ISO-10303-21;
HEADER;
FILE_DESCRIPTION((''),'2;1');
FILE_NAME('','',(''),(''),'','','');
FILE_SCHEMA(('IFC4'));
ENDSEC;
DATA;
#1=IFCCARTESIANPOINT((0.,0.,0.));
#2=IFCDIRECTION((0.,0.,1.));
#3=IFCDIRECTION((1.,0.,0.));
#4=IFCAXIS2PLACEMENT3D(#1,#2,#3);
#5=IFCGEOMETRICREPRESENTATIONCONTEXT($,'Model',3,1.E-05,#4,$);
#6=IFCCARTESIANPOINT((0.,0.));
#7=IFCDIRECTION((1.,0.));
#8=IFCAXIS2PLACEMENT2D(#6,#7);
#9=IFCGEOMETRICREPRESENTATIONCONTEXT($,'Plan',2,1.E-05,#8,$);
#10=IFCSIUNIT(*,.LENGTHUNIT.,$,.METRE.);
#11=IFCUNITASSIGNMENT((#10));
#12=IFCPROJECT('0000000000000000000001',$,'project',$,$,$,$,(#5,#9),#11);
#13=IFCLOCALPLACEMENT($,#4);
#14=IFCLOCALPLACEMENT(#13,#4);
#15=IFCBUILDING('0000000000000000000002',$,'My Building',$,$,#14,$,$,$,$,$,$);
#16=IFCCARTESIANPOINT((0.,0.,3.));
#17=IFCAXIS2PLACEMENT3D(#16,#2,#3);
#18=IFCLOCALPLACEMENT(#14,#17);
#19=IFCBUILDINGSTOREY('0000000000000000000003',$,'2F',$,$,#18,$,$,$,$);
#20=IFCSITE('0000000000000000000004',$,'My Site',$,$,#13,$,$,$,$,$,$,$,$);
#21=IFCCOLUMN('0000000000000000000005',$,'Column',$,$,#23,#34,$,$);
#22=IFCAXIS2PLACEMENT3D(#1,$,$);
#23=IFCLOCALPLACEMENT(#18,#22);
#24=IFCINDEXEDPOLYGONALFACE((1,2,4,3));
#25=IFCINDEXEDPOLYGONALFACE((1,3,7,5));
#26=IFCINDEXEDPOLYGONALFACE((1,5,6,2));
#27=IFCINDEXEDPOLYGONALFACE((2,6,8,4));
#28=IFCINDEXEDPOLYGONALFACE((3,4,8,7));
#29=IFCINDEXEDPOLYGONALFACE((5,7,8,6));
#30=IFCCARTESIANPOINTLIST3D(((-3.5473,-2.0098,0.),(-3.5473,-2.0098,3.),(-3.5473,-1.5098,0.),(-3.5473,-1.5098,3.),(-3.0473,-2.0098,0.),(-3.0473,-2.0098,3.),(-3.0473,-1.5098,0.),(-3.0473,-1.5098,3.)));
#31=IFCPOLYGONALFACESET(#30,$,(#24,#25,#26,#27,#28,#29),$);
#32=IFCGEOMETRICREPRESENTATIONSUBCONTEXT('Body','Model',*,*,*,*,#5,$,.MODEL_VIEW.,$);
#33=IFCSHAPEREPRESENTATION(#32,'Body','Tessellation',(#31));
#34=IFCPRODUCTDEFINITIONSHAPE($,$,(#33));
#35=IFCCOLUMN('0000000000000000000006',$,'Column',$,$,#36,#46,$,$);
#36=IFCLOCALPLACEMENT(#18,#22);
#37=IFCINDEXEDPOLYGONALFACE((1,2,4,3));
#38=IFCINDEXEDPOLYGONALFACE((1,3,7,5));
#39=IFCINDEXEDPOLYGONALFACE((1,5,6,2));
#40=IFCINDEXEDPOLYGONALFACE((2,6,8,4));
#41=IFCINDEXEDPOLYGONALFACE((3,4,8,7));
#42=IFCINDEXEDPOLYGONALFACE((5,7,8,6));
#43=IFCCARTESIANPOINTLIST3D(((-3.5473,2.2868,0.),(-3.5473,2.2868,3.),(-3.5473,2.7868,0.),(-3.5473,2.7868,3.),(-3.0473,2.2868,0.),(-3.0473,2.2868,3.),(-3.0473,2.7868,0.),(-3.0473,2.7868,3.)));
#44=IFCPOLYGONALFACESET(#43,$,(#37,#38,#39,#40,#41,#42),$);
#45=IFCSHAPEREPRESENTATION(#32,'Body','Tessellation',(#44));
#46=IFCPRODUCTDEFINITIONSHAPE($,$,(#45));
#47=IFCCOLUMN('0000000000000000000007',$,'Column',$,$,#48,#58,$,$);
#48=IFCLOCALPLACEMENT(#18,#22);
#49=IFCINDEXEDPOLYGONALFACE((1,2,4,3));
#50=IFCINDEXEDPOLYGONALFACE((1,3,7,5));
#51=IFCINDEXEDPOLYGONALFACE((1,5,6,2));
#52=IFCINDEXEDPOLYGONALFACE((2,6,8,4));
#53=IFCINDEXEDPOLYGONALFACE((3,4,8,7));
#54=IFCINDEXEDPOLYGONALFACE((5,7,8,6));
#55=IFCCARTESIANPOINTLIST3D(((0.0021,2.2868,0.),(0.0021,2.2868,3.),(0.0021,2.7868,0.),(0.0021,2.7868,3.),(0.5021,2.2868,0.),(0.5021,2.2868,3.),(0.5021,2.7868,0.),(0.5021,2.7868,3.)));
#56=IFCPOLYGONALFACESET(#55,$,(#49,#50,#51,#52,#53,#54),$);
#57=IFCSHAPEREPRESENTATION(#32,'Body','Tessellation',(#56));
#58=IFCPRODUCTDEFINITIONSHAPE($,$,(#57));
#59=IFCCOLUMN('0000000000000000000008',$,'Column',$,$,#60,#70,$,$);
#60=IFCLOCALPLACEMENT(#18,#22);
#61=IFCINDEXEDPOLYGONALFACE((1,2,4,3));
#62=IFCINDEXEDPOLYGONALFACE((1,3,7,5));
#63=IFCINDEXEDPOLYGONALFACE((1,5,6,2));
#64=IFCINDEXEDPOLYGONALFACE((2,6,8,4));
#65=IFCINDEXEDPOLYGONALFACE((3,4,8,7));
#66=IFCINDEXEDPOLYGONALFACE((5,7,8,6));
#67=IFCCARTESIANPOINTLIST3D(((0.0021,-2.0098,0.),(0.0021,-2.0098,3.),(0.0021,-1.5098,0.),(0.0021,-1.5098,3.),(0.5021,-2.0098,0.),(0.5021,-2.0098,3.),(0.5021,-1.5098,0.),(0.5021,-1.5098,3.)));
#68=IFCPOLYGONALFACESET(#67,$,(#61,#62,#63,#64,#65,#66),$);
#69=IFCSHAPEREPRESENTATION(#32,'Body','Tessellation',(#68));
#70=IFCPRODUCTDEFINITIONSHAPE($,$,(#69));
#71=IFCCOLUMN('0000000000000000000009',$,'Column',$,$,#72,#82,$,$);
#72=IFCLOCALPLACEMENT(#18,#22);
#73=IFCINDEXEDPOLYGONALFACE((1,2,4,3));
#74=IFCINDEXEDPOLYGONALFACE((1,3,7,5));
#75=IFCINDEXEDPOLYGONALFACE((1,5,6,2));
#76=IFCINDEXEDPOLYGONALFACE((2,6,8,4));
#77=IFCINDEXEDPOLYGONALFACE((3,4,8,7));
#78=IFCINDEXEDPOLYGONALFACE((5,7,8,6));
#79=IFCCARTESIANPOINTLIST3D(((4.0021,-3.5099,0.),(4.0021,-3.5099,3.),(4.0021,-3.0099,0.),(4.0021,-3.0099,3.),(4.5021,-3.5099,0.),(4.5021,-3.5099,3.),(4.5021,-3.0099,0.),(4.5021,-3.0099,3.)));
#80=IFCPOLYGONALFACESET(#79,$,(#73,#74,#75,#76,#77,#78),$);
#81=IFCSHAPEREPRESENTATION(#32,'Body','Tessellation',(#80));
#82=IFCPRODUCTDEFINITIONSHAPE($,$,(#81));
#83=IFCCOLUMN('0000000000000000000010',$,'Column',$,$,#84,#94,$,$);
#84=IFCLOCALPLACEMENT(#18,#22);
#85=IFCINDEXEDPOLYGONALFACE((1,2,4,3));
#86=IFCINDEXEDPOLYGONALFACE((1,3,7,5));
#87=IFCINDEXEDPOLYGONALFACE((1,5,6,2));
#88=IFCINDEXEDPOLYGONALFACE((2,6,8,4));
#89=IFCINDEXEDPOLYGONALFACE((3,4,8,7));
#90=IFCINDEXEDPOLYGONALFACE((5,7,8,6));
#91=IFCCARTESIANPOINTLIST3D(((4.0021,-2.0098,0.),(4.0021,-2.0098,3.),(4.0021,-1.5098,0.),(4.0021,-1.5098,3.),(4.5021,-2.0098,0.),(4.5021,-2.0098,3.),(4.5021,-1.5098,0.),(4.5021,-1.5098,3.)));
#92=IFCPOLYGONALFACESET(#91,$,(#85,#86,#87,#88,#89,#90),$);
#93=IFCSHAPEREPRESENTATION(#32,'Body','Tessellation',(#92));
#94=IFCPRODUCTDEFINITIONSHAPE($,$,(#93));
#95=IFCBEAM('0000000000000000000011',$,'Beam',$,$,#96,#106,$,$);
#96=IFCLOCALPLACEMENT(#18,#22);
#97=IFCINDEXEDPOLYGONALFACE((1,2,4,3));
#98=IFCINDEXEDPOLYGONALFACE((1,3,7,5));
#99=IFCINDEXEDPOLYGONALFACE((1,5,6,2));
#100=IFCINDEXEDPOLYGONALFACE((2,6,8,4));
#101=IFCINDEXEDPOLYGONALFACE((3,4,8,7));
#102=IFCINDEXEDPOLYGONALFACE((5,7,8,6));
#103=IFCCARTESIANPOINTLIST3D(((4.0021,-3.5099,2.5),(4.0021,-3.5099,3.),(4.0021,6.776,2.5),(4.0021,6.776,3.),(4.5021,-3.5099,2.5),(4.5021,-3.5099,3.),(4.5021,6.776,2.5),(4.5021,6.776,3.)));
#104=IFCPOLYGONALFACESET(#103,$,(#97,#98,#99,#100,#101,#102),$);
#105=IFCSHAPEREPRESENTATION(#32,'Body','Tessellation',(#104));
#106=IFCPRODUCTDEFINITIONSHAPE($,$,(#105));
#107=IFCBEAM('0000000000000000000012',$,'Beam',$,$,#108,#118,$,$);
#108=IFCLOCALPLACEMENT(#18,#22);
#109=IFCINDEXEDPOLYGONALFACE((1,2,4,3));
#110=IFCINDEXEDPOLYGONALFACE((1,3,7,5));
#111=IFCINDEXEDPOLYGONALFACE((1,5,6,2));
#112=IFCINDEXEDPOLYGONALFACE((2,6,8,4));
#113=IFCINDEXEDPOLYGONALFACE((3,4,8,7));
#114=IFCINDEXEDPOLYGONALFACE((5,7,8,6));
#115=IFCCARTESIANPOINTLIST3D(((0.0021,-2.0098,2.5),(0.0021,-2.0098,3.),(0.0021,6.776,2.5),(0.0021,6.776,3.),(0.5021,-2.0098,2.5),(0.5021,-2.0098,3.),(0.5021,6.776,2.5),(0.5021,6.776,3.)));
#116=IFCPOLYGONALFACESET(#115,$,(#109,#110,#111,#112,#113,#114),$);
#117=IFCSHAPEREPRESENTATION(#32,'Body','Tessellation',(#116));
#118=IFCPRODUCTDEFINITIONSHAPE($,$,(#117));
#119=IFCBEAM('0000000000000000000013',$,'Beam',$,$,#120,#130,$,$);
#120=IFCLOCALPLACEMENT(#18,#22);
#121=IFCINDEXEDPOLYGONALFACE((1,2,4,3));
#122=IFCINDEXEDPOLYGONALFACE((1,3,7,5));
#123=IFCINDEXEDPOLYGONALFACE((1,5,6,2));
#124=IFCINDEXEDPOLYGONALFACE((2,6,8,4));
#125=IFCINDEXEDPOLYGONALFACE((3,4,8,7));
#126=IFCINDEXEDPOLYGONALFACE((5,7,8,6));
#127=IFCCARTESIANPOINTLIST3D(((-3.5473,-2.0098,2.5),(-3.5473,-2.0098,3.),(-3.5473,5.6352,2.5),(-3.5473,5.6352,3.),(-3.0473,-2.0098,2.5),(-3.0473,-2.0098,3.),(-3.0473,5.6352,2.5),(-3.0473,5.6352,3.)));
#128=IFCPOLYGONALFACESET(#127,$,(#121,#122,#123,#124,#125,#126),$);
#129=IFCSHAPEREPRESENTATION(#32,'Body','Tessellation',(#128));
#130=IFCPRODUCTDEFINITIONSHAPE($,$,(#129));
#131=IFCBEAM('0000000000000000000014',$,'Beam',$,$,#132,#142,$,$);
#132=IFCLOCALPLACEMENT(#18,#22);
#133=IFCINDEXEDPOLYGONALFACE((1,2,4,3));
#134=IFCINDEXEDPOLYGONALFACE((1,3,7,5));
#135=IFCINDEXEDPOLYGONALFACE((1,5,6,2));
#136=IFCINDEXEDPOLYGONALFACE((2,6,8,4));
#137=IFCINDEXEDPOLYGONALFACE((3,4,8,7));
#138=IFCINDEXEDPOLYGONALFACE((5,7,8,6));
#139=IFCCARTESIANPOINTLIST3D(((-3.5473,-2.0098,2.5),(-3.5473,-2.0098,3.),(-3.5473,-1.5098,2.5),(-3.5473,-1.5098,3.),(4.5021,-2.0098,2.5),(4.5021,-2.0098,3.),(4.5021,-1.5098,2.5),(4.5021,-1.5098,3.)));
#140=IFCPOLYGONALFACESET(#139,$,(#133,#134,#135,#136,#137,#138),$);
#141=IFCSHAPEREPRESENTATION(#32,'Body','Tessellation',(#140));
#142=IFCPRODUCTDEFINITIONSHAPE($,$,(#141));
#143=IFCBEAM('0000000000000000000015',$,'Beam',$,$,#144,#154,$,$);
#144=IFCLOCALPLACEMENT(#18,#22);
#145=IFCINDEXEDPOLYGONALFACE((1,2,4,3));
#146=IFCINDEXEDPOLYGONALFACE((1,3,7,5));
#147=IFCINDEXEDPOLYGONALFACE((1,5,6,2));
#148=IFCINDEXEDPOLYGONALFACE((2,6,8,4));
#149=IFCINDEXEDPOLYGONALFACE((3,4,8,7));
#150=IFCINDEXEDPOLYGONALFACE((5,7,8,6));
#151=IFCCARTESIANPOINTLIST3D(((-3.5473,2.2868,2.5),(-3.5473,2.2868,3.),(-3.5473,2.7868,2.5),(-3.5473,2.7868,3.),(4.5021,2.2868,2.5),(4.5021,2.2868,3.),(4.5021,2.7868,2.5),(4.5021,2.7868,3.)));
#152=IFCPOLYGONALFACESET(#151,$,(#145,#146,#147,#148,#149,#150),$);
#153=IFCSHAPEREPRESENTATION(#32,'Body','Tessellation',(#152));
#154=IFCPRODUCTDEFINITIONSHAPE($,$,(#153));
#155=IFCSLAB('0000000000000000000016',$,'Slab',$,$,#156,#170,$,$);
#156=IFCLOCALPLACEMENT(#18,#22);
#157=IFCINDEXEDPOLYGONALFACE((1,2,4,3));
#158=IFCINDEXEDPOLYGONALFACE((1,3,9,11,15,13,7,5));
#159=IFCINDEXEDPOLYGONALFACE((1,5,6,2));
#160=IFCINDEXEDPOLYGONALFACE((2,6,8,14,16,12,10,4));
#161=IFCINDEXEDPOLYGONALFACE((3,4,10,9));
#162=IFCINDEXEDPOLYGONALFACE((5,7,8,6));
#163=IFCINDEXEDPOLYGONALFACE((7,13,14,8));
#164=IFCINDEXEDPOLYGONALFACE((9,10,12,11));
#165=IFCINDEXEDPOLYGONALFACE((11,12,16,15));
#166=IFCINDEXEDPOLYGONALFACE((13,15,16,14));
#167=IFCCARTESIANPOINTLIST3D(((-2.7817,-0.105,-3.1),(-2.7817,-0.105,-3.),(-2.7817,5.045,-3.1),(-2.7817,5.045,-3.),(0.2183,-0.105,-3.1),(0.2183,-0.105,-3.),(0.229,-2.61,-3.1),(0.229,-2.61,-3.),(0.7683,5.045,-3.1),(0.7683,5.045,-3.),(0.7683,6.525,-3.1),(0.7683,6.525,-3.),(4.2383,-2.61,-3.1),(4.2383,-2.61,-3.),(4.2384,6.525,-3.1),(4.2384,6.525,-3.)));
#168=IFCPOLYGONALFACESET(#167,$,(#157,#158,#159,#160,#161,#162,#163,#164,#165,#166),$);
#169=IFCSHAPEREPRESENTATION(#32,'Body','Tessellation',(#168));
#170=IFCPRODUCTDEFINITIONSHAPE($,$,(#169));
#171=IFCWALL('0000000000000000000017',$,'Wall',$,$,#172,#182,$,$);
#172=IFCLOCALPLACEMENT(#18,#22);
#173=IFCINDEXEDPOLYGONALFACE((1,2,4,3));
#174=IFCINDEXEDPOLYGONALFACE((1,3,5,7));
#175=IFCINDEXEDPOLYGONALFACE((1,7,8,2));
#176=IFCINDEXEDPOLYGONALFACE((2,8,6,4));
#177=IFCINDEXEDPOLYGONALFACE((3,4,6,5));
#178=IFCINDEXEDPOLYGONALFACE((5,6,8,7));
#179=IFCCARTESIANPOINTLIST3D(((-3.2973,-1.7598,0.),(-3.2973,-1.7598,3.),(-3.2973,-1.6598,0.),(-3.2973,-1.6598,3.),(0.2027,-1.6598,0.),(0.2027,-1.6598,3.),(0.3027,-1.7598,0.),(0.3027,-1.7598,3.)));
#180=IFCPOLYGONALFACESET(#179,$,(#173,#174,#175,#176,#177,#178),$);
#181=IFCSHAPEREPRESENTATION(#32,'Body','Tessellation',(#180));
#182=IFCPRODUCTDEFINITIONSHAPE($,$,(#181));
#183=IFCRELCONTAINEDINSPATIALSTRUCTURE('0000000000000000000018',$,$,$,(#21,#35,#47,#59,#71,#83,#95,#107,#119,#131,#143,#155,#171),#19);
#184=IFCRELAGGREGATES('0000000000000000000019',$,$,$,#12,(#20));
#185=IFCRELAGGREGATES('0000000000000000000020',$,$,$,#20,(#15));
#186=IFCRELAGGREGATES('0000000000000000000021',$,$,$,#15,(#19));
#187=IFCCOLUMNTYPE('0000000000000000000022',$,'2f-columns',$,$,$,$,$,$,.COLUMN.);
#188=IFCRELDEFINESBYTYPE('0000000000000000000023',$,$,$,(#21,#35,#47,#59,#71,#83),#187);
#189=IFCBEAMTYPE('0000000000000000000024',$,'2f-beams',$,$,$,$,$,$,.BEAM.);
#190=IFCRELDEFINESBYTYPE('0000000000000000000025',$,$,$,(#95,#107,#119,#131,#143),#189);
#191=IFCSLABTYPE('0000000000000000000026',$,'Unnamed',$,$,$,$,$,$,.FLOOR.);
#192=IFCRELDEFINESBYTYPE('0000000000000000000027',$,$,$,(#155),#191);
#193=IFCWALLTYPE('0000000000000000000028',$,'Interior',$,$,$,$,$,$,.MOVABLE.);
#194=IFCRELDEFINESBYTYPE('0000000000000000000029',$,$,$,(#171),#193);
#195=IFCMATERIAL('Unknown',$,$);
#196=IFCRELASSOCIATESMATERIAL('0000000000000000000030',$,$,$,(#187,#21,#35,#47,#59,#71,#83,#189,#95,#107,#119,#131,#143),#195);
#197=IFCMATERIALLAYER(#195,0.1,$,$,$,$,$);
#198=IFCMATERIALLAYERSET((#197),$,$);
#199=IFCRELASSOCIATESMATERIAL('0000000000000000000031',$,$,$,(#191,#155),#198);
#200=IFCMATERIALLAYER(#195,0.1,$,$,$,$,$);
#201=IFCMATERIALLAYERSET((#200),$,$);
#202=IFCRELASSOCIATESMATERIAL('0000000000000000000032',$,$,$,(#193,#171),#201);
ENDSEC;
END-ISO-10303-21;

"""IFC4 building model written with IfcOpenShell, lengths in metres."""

from ifc_helpers import new_model, si_unit, frame, origin_with_axes, origin_2d_with_axis, place, context, subcontext, project, spatial, line, indexed_curve, rectangle, outline, extrude, material, layer, layer_set, layer_usage, material_profile, profile_set, profile_usage, type_object, element, save


model = new_model("IFC4")

# Units and contexts
model_context = context("Model", 3, precision=1e-05, world=origin_with_axes())
plan_context = context("Plan", 2, precision=1e-05, world=origin_2d_with_axis())
body_context_1 = subcontext(model_context, "Body", "Model", "MODEL_VIEW")
ifc_project = project(units=[si_unit("LENGTHUNIT", "METRE")], contexts=[model_context, plan_context])

# Site, building, storey
site_placement = place(None, origin_with_axes())
site = spatial("IfcSite", under=ifc_project, at=site_placement, Name="My Site")
building_placement = place(site_placement, origin_with_axes())
building = spatial("IfcBuilding", under=site, at=building_placement, Name="My Building")
storey_placement = place(building_placement, frame((0.0, 0.0, 3.0), z_axis=(0.0, 0.0, 1.0), x_axis=(1.0, 0.0, 0.0)))
storey = spatial("IfcBuildingStorey", under=building, at=storey_placement, Name="2F")

# Columns
ifc_material = material(Name="Unknown")
ifc_material_profile_1 = material_profile(ifc_material, rectangle(XDim=0.5, YDim=0.5))
ifc_profile_set_1 = profile_set([ifc_material_profile_1])
ifc_profile_usage_1 = profile_usage(ifc_profile_set_1, cardinal=5)
column_type = type_object("IfcColumnType", Name="2f-columns", PredefinedType="COLUMN", material=ifc_profile_set_1)
column_1_placement = place(storey_placement, frame((-3.2973, -1.7598, 0.0), z_axis=(0.0, 0.0, 1.0), x_axis=(1.0, 0.0, 0.0)))
element("IfcColumn", 1, at=column_1_placement, inside=storey, type_object=column_type, material=ifc_profile_usage_1, Name="Column", context=body_context_1, shape_type="SweptSolid", body=[
    extrude(rectangle(XDim=0.5, YDim=0.5), origin_with_axes(), (0.0, 0.0, 1.0), 3.0),
])
ifc_profile_usage_2 = profile_usage(ifc_profile_set_1, cardinal=5)
column_2_placement = place(storey_placement, frame((-3.2973, 2.5368, 0.0), z_axis=(0.0, 0.0, 1.0), x_axis=(1.0, 0.0, 0.0)))
element("IfcColumn", 2, at=column_2_placement, inside=storey, type_object=column_type, material=ifc_profile_usage_2, Name="Column", context=body_context_1, shape_type="SweptSolid", body=[
    extrude(rectangle(XDim=0.5, YDim=0.5), origin_with_axes(), (0.0, 0.0, 1.0), 3.0),
])
ifc_profile_usage_3 = profile_usage(ifc_profile_set_1, cardinal=5)
column_3_placement = place(storey_placement, frame((0.2521, 2.5368, 0.0), z_axis=(0.0, 0.0, 1.0), x_axis=(1.0, 0.0, 0.0)))
element("IfcColumn", 3, at=column_3_placement, inside=storey, type_object=column_type, material=ifc_profile_usage_3, Name="Column", context=body_context_1, shape_type="SweptSolid", body=[
    extrude(rectangle(XDim=0.5, YDim=0.5), origin_with_axes(), (0.0, 0.0, 1.0), 3.0),
])
ifc_profile_usage_4 = profile_usage(ifc_profile_set_1, cardinal=5)
column_4_placement = place(storey_placement, frame((0.2521, -1.7598, 0.0), z_axis=(0.0, 0.0, 1.0), x_axis=(1.0, 0.0, 0.0)))
element("IfcColumn", 4, at=column_4_placement, inside=storey, type_object=column_type, material=ifc_profile_usage_4, Name="Column", context=body_context_1, shape_type="SweptSolid", body=[
    extrude(rectangle(XDim=0.5, YDim=0.5), origin_with_axes(), (0.0, 0.0, 1.0), 3.0),
])
ifc_profile_usage_5 = profile_usage(ifc_profile_set_1, cardinal=5)
column_5_placement = place(storey_placement, frame((4.2521, -3.2599, 0.0), z_axis=(0.0, 0.0, 1.0), x_axis=(1.0, 0.0, 0.0)))
element("IfcColumn", 5, at=column_5_placement, inside=storey, type_object=column_type, material=ifc_profile_usage_5, Name="Column", context=body_context_1, shape_type="SweptSolid", body=[
    extrude(rectangle(XDim=0.5, YDim=0.5), origin_with_axes(), (0.0, 0.0, 1.0), 3.0),
])
ifc_profile_usage_6 = profile_usage(ifc_profile_set_1, cardinal=5)
column_6_placement = place(storey_placement, frame((4.2521, -1.7598, 0.0), z_axis=(0.0, 0.0, 1.0), x_axis=(1.0, 0.0, 0.0)))
element("IfcColumn", 6, at=column_6_placement, inside=storey, type_object=column_type, material=ifc_profile_usage_6, Name="Column", context=body_context_1, shape_type="SweptSolid", body=[
    extrude(rectangle(XDim=0.5, YDim=0.5), origin_with_axes(), (0.0, 0.0, 1.0), 3.0),
])

# Beams
ifc_material_profile_2 = material_profile(ifc_material, rectangle(XDim=0.5, YDim=0.5))
ifc_profile_set_2 = profile_set([ifc_material_profile_2])
ifc_profile_usage_7 = profile_usage(ifc_profile_set_2, cardinal=7)
beam_type = type_object("IfcBeamType", Name="2f-beams", PredefinedType="BEAM", material=ifc_profile_set_2)
beam_1_placement = place(storey_placement, frame((4.0021, -3.5099, 3.0), z_axis=(0.0, 1.0, 0.0), x_axis=(-1.0, 0.0, 0.0)))
element("IfcBeam", 7, at=beam_1_placement, inside=storey, type_object=beam_type, material=ifc_profile_usage_7, Name="Beam", context=body_context_1, shape_type="SweptSolid", body=[
    extrude(rectangle(XDim=0.5, YDim=0.5), frame((-0.25, -0.25, 0.0), z_axis=(0.0, 0.0, 1.0), x_axis=(1.0, 0.0, 0.0)), (0.0, 0.0, 1.0), 10.2859),
])
ifc_profile_usage_8 = profile_usage(ifc_profile_set_2, cardinal=7)
beam_2_placement = place(storey_placement, frame((0.0021, -2.0098, 3.0), z_axis=(0.0, 1.0, 0.0), x_axis=(-1.0, 0.0, 0.0)))
element("IfcBeam", 8, at=beam_2_placement, inside=storey, type_object=beam_type, material=ifc_profile_usage_8, Name="Beam", context=body_context_1, shape_type="SweptSolid", body=[
    extrude(rectangle(XDim=0.5, YDim=0.5), frame((-0.25, -0.25, 0.0), z_axis=(0.0, 0.0, 1.0), x_axis=(1.0, 0.0, 0.0)), (0.0, 0.0, 1.0), 8.7858),
])
ifc_profile_usage_9 = profile_usage(ifc_profile_set_2, cardinal=7)
beam_3_placement = place(storey_placement, frame((-3.5473, -2.0098, 3.0), z_axis=(0.0, 1.0, 0.0), x_axis=(-1.0, 0.0, 0.0)))
element("IfcBeam", 9, at=beam_3_placement, inside=storey, type_object=beam_type, material=ifc_profile_usage_9, Name="Beam", context=body_context_1, shape_type="SweptSolid", body=[
    extrude(rectangle(XDim=0.5, YDim=0.5), frame((-0.25, -0.25, 0.0), z_axis=(0.0, 0.0, 1.0), x_axis=(1.0, 0.0, 0.0)), (0.0, 0.0, 1.0), 7.645),
])
ifc_profile_usage_10 = profile_usage(ifc_profile_set_2, cardinal=7)
beam_4_placement = place(storey_placement, frame((4.5021, -2.0098, 3.0), z_axis=(-1.0, 0.0, 0.0), x_axis=(0.0, -1.0, 0.0)))
element("IfcBeam", 10, at=beam_4_placement, inside=storey, type_object=beam_type, material=ifc_profile_usage_10, Name="Beam", context=body_context_1, shape_type="SweptSolid", body=[
    extrude(rectangle(XDim=0.5, YDim=0.5), frame((-0.25, -0.25, 0.0), z_axis=(0.0, 0.0, 1.0), x_axis=(1.0, 0.0, 0.0)), (0.0, 0.0, 1.0), 8.0493),
])
ifc_profile_usage_11 = profile_usage(ifc_profile_set_2, cardinal=7)
beam_5_placement = place(storey_placement, frame((4.5021, 2.2868, 3.0), z_axis=(-1.0, 0.0, 0.0), x_axis=(0.0, -1.0, 0.0)))
element("IfcBeam", 11, at=beam_5_placement, inside=storey, type_object=beam_type, material=ifc_profile_usage_11, Name="Beam", context=body_context_1, shape_type="SweptSolid", body=[
    extrude(rectangle(XDim=0.5, YDim=0.5), frame((-0.25, -0.25, 0.0), z_axis=(0.0, 0.0, 1.0), x_axis=(1.0, 0.0, 0.0)), (0.0, 0.0, 1.0), 8.0493),
])

# Slab
ifc_layer_1 = layer(ifc_material, 0.1)
ifc_layer_set_1 = layer_set([ifc_layer_1])
ifc_layer_usage_1 = layer_usage(ifc_layer_set_1, "AXIS3", "POSITIVE", -0.1)
slab_type = type_object("IfcSlabType", Name="Unnamed", PredefinedType="FLOOR", material=ifc_layer_set_1)
slab_placement = place(storey_placement, frame((4.2383, -2.61, -3.0), z_axis=(0.0, 0.0, 1.0), x_axis=(1.0, 0.0, 0.0)))
element("IfcSlab", 12, at=slab_placement, inside=storey, type_object=slab_type, material=ifc_layer_usage_1, Name="Slab", context=body_context_1, shape_type="SweptSolid", body=[
    extrude(outline(indexed_curve([(0.0, 0.0), (0.0, 9.135), (-3.47, 9.135), (-3.47, 7.655), (-7.02, 7.655), (-7.02, 2.505), (-4.02, 2.505), (-4.0094, 0.0), (0.0, 0.0)])), frame((0.0, 0.0, -0.1), z_axis=(0.0, 0.0, 1.0), x_axis=(1.0, 0.0, 0.0)), (0.0, 0.0, 1.0), 0.1),
])

# Wall
ifc_layer_2 = layer(ifc_material, 0.1)
ifc_layer_set_2 = layer_set([ifc_layer_2])
ifc_layer_usage_2 = layer_usage(ifc_layer_set_2, "AXIS2", "POSITIVE", 0.0)
wall_type = type_object("IfcWallType", Name="Interior", PredefinedType="MOVABLE", material=ifc_layer_set_2)
wall_1_placement = place(storey_placement, frame((-3.2973, -1.7598, 0.0), z_axis=(0.0, 0.0, 1.0), x_axis=(1.0, 0.0, 0.0)))
element("IfcWall", 13, at=wall_1_placement, inside=storey, type_object=wall_type, material=ifc_layer_usage_2, Name="Wall", context=body_context_1, shape_type="SweptSolid", body=[
    extrude(outline(indexed_curve([(0.0, 0.0), (0.0, 0.1), (3.5, 0.1), (3.6, 0.0)], segments=[line(1, 2, 3, 4, 1)])), origin_with_axes(), (0.0, 0.0, 1.0), 3.0),
])

save(model, "model.ifc")
